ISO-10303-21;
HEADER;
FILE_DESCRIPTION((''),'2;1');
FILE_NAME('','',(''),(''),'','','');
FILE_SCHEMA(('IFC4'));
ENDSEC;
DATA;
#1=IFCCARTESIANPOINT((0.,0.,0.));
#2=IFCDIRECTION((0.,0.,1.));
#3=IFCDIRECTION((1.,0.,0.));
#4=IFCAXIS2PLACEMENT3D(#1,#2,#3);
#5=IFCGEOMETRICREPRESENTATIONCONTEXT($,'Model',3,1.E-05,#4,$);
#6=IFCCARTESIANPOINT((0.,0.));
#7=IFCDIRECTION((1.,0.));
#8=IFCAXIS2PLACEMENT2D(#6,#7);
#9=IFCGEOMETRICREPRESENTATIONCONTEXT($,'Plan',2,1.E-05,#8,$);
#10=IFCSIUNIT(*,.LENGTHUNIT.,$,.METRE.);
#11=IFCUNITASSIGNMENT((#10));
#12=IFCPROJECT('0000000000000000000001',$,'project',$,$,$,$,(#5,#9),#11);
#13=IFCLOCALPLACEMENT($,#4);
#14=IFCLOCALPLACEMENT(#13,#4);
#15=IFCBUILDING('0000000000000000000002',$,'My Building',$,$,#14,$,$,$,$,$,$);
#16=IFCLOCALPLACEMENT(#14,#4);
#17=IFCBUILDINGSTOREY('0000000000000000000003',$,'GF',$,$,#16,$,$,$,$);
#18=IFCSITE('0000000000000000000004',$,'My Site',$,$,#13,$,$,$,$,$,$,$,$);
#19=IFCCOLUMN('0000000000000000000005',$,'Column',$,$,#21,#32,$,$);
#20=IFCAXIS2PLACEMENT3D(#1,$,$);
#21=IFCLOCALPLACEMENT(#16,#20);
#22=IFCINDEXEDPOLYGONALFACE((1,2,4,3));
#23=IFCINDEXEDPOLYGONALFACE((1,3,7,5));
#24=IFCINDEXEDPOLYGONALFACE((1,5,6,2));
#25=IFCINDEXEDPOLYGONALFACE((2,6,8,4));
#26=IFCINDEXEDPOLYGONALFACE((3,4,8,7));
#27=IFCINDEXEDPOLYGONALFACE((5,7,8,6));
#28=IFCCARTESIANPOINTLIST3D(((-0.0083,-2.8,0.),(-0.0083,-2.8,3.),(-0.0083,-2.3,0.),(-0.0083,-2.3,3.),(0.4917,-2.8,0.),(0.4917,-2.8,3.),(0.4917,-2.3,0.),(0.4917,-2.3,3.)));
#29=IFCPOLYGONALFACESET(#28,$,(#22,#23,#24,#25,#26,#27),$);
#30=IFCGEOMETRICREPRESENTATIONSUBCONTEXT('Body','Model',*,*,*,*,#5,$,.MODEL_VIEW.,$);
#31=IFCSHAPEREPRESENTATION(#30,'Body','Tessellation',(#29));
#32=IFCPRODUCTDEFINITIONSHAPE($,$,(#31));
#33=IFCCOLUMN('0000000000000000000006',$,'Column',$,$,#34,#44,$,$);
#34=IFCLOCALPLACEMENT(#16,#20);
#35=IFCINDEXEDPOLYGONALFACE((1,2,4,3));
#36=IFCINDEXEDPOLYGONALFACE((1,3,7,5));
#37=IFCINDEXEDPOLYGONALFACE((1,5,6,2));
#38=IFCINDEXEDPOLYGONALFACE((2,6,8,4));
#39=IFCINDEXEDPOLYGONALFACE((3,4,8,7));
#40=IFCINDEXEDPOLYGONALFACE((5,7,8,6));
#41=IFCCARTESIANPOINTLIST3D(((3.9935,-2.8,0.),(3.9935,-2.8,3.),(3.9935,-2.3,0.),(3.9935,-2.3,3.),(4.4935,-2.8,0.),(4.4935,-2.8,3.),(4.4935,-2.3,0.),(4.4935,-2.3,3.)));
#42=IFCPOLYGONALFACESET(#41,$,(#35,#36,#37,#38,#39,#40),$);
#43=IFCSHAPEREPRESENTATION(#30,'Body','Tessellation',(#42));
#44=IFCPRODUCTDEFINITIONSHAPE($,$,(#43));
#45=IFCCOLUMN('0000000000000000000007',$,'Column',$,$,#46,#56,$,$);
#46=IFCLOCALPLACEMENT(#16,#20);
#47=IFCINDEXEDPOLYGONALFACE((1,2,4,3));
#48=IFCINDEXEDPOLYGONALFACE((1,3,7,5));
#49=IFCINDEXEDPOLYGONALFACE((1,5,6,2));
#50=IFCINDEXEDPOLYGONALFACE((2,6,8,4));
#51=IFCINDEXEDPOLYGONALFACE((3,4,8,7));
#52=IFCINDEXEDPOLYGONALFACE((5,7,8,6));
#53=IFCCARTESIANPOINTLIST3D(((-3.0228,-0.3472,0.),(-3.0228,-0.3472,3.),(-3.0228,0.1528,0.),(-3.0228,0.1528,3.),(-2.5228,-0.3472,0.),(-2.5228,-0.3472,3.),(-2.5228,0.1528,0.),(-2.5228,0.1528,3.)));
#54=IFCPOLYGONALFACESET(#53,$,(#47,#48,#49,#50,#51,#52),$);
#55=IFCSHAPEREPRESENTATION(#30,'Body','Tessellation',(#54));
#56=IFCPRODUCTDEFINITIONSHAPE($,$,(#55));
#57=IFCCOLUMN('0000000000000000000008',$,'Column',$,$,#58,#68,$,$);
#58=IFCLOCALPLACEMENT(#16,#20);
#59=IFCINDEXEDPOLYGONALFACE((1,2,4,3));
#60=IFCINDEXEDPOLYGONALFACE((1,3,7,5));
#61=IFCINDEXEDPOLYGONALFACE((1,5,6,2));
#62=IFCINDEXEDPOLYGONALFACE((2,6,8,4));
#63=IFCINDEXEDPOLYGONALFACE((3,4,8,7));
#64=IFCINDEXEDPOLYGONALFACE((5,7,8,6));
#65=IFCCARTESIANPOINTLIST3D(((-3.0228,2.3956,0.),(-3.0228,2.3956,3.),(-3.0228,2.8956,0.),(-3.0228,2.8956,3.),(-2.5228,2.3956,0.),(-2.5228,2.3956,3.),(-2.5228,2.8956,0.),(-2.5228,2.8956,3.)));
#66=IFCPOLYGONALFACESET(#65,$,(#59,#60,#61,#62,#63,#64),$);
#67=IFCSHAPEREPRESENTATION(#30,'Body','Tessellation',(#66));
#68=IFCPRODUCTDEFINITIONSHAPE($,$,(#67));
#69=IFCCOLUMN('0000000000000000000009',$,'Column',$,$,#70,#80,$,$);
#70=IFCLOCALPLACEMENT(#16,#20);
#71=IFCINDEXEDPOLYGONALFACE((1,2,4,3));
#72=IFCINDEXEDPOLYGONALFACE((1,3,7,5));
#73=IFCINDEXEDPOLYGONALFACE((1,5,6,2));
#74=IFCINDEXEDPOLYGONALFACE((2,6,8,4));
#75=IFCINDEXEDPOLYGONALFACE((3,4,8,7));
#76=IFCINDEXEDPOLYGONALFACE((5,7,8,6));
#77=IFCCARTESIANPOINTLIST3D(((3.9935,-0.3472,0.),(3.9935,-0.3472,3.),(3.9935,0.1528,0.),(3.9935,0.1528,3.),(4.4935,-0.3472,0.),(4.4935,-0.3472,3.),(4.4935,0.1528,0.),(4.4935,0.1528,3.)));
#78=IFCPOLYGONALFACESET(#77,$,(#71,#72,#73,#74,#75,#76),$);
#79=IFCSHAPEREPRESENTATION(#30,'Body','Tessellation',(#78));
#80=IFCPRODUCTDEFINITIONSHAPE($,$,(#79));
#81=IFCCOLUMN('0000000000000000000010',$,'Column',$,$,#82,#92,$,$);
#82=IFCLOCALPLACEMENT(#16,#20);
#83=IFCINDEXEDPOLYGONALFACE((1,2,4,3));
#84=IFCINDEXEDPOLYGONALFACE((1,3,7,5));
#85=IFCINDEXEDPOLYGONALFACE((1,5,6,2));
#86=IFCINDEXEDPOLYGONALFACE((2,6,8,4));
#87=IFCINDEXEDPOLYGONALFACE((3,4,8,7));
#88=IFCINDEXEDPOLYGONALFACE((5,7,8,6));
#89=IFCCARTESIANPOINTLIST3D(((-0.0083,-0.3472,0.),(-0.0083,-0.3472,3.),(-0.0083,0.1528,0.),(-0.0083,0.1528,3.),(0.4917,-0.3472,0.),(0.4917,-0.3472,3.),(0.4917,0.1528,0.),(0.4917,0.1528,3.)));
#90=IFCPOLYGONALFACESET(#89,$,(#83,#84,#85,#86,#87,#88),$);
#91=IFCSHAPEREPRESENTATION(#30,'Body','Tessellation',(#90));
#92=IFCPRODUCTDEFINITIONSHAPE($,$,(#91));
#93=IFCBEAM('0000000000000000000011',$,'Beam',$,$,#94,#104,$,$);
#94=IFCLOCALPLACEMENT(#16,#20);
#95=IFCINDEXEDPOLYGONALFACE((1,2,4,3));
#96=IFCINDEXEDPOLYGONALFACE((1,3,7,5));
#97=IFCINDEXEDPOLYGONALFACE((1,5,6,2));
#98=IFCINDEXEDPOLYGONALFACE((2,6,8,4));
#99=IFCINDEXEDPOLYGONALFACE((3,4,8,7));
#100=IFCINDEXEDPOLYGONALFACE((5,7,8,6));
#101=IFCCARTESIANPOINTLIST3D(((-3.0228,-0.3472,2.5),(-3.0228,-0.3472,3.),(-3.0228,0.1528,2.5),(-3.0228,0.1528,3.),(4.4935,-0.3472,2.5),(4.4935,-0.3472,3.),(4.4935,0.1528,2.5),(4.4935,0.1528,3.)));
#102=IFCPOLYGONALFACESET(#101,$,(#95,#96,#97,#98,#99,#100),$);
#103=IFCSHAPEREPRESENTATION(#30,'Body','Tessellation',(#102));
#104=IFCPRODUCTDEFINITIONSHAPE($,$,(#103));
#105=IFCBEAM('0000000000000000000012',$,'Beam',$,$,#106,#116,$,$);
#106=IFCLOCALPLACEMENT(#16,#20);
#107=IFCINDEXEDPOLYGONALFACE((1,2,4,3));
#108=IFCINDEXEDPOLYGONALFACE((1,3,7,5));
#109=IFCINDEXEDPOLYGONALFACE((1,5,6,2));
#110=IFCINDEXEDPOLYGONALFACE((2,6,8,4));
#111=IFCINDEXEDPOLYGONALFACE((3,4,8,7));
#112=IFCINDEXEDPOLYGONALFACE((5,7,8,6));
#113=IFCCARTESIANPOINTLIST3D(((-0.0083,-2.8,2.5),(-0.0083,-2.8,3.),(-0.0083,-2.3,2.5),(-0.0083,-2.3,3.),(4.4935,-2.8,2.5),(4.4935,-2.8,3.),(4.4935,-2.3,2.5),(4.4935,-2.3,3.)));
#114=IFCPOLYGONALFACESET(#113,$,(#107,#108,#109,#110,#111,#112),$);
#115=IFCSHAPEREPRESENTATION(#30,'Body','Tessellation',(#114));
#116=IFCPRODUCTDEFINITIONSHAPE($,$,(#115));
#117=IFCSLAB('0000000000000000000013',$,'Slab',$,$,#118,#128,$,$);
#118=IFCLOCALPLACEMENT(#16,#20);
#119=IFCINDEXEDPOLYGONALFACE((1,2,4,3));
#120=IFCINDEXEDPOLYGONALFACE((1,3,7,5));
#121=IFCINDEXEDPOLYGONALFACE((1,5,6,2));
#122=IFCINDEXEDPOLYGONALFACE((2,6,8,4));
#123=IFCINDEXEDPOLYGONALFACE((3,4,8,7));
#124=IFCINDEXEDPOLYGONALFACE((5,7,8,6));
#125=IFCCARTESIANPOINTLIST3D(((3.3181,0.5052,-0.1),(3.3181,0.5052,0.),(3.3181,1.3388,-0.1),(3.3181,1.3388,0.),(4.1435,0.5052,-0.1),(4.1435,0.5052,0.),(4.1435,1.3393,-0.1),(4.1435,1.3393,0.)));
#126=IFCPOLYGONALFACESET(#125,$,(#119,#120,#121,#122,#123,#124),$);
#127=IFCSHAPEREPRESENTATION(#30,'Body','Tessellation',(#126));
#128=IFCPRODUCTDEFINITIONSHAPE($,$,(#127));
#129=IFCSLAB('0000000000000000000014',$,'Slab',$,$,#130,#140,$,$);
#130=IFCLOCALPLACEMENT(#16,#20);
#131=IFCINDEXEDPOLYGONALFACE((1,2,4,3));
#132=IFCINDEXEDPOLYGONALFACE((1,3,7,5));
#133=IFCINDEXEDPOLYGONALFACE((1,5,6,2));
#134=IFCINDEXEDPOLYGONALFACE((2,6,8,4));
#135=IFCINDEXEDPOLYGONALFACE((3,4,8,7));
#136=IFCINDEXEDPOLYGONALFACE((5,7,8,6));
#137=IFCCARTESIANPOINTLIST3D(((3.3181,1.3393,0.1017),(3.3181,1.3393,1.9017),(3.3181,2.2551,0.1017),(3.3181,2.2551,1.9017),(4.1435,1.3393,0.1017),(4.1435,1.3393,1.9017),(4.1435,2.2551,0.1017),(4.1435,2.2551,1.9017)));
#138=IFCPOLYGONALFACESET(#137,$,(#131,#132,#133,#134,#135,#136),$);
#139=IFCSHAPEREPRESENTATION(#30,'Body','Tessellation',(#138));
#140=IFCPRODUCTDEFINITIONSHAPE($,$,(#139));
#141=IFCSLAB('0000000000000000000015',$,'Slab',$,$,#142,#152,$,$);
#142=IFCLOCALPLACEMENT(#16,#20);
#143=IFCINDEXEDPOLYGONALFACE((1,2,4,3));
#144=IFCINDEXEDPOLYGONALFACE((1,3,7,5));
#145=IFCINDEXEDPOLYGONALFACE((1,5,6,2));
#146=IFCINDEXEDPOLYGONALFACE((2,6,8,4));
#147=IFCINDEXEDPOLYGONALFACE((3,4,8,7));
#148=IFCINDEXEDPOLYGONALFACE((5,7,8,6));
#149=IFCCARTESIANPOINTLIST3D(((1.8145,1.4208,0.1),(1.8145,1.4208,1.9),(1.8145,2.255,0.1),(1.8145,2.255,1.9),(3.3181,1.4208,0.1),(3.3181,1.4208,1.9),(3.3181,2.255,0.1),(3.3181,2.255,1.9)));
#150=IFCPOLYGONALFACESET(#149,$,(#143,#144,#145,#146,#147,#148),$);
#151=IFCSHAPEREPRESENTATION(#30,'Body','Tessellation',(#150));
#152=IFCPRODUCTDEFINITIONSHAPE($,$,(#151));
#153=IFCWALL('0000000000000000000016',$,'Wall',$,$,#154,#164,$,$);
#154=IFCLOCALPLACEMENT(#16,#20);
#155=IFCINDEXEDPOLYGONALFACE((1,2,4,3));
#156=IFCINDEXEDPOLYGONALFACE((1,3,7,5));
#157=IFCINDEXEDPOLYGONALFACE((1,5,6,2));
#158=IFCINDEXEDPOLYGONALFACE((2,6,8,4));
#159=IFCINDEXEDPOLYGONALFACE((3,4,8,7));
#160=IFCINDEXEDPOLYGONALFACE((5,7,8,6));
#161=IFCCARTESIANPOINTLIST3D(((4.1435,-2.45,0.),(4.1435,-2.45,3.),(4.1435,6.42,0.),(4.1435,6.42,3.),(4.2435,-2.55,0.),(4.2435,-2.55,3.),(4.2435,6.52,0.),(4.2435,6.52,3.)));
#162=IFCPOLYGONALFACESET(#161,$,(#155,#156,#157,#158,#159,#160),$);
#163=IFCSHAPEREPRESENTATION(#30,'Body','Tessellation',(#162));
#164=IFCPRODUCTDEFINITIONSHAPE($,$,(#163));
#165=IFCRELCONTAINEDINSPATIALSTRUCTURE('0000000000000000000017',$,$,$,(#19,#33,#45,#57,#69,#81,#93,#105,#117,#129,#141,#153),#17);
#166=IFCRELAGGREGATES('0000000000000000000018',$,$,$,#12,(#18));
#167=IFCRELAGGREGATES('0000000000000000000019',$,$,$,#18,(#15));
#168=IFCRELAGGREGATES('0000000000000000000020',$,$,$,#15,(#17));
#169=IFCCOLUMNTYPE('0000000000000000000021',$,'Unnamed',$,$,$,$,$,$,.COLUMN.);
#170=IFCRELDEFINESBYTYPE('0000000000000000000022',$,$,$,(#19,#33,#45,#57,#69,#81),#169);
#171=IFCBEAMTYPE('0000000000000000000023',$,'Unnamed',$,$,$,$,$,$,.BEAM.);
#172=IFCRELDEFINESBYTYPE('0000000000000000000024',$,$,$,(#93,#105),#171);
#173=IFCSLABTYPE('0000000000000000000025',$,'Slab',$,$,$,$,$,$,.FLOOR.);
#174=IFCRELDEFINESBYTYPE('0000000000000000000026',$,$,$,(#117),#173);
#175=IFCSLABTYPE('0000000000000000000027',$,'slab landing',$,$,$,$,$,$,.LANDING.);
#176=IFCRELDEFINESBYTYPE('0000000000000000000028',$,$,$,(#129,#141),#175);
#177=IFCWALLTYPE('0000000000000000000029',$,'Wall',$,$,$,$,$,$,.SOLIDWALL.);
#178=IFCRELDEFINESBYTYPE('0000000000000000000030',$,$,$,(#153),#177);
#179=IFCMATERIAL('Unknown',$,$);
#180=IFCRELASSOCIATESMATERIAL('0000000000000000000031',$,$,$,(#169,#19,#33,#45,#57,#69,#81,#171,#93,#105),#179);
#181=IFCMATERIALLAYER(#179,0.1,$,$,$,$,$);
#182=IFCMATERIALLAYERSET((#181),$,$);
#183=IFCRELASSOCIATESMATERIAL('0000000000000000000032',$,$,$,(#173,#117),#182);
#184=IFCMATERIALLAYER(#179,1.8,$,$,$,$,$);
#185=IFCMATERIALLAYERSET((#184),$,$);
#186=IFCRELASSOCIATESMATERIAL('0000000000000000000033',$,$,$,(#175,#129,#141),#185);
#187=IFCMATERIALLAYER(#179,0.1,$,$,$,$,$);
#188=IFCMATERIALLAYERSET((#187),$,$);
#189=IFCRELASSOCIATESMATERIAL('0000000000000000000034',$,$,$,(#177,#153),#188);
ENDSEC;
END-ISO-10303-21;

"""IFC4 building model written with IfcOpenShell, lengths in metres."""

from ifc_helpers import new_model, si_unit, frame, origin_with_axes, origin_2d_with_axis, place, context, subcontext, project, spatial, line, indexed_curve, rectangle, outline, extrude, material, layer, layer_set, layer_usage, material_profile, profile_set, profile_usage, type_object, element, save


model = new_model("IFC4")

# Units and contexts
model_context = context("Model", 3, precision=1e-05, world=origin_with_axes())
plan_context = context("Plan", 2, precision=1e-05, world=origin_2d_with_axis())
body_context_1 = subcontext(model_context, "Body", "Model", "MODEL_VIEW")
ifc_project = project(units=[si_unit("LENGTHUNIT", "METRE")], contexts=[model_context, plan_context])

# Site, building, storey
site_placement = place(None, origin_with_axes())
site = spatial("IfcSite", under=ifc_project, at=site_placement, Name="My Site")
building_placement = place(site_placement, origin_with_axes())
building = spatial("IfcBuilding", under=site, at=building_placement, Name="My Building")
storey_placement = place(building_placement, origin_with_axes())
storey = spatial("IfcBuildingStorey", under=building, at=storey_placement, Name="GF")

# Columns
ifc_material = material(Name="Unknown")
ifc_material_profile_1 = material_profile(ifc_material, rectangle(XDim=0.5, YDim=0.5))
ifc_profile_set_1 = profile_set([ifc_material_profile_1])
ifc_profile_usage_1 = profile_usage(ifc_profile_set_1, cardinal=5)
column_type = type_object("IfcColumnType", Name="Unnamed", PredefinedType="COLUMN", material=ifc_profile_set_1)
column_1_placement = place(storey_placement, frame((0.2417, -2.55, 0.0), z_axis=(0.0, 0.0, 1.0), x_axis=(1.0, 0.0, 0.0)))
element("IfcColumn", 1, at=column_1_placement, inside=storey, type_object=column_type, material=ifc_profile_usage_1, Name="Column", context=body_context_1, shape_type="SweptSolid", body=[
    extrude(rectangle(XDim=0.5, YDim=0.5), origin_with_axes(), (0.0, 0.0, 1.0), 3.0),
])
ifc_profile_usage_2 = profile_usage(ifc_profile_set_1, cardinal=5)
column_2_placement = place(storey_placement, frame((4.2435, -2.55, 0.0), z_axis=(0.0, 0.0, 1.0), x_axis=(1.0, 0.0, 0.0)))
element("IfcColumn", 2, at=column_2_placement, inside=storey, type_object=column_type, material=ifc_profile_usage_2, Name="Column", context=body_context_1, shape_type="SweptSolid", body=[
    extrude(rectangle(XDim=0.5, YDim=0.5), origin_with_axes(), (0.0, 0.0, 1.0), 3.0),
])
ifc_profile_usage_3 = profile_usage(ifc_profile_set_1, cardinal=5)
column_3_placement = place(storey_placement, frame((-2.7728, -0.0972, 0.0), z_axis=(0.0, 0.0, 1.0), x_axis=(1.0, 0.0, 0.0)))
element("IfcColumn", 3, at=column_3_placement, inside=storey, type_object=column_type, material=ifc_profile_usage_3, Name="Column", context=body_context_1, shape_type="SweptSolid", body=[
    extrude(rectangle(XDim=0.5, YDim=0.5), origin_with_axes(), (0.0, 0.0, 1.0), 3.0),
])
ifc_profile_usage_4 = profile_usage(ifc_profile_set_1, cardinal=5)
column_4_placement = place(storey_placement, frame((-2.7728, 2.6456, 0.0), z_axis=(0.0, 0.0, 1.0), x_axis=(1.0, 0.0, 0.0)))
element("IfcColumn", 4, at=column_4_placement, inside=storey, type_object=column_type, material=ifc_profile_usage_4, Name="Column", context=body_context_1, shape_type="SweptSolid", body=[
    extrude(rectangle(XDim=0.5, YDim=0.5), origin_with_axes(), (0.0, 0.0, 1.0), 3.0),
])
ifc_profile_usage_5 = profile_usage(ifc_profile_set_1, cardinal=5)
column_5_placement = place(storey_placement, frame((4.2435, -0.0972, 0.0), z_axis=(0.0, 0.0, 1.0), x_axis=(1.0, 0.0, 0.0)))
element("IfcColumn", 5, at=column_5_placement, inside=storey, type_object=column_type, material=ifc_profile_usage_5, Name="Column", context=body_context_1, shape_type="SweptSolid", body=[
    extrude(rectangle(XDim=0.5, YDim=0.5), origin_with_axes(), (0.0, 0.0, 1.0), 3.0),
])
ifc_profile_usage_6 = profile_usage(ifc_profile_set_1, cardinal=5)
column_6_placement = place(storey_placement, frame((0.2417, -0.0972, 0.0), z_axis=(0.0, 0.0, 1.0), x_axis=(1.0, 0.0, 0.0)))
element("IfcColumn", 6, at=column_6_placement, inside=storey, type_object=column_type, material=ifc_profile_usage_6, Name="Column", context=body_context_1, shape_type="SweptSolid", body=[
    extrude(rectangle(XDim=0.5, YDim=0.5), origin_with_axes(), (0.0, 0.0, 1.0), 3.0),
])

# Beams
ifc_material_profile_2 = material_profile(ifc_material, rectangle(XDim=0.5, YDim=0.5))
ifc_profile_set_2 = profile_set([ifc_material_profile_2])
ifc_profile_usage_7 = profile_usage(ifc_profile_set_2, cardinal=7)
beam_type = type_object("IfcBeamType", Name="Unnamed", PredefinedType="BEAM", material=ifc_profile_set_2)
beam_1_placement = place(storey_placement, frame((-3.0228, 0.1528, 3.0), z_axis=(1.0, 0.0, 0.0), x_axis=(0.0, 1.0, 0.0)))
element("IfcBeam", 7, at=beam_1_placement, inside=storey, type_object=beam_type, material=ifc_profile_usage_7, Name="Beam", context=body_context_1, shape_type="SweptSolid", body=[
    extrude(rectangle(XDim=0.5, YDim=0.5), frame((-0.25, -0.25, 0.0), z_axis=(0.0, 0.0, 1.0), x_axis=(1.0, 0.0, 0.0)), (0.0, 0.0, 1.0), 7.5163),
])
ifc_profile_usage_8 = profile_usage(ifc_profile_set_2, cardinal=7)
beam_2_placement = place(storey_placement, frame((4.4935, -2.8, 3.0), z_axis=(-1.0, 0.0, 0.0), x_axis=(0.0, -1.0, 0.0)))
element("IfcBeam", 8, at=beam_2_placement, inside=storey, type_object=beam_type, material=ifc_profile_usage_8, Name="Beam", context=body_context_1, shape_type="SweptSolid", body=[
    extrude(rectangle(XDim=0.5, YDim=0.5), frame((-0.25, -0.25, 0.0), z_axis=(0.0, 0.0, 1.0), x_axis=(1.0, 0.0, 0.0)), (0.0, 0.0, 1.0), 4.5018),
])

# Slabs
ifc_layer_1 = layer(ifc_material, 0.1)
ifc_layer_set_1 = layer_set([ifc_layer_1])
ifc_layer_usage_1 = layer_usage(ifc_layer_set_1, "AXIS3", "POSITIVE", -0.1)
slab_type_1 = type_object("IfcSlabType", Name="Slab", PredefinedType="FLOOR", material=ifc_layer_set_1)
slab_1_placement = place(storey_placement, frame((3.3181, 1.3388, 0.0), z_axis=(0.0, 0.0, 1.0), x_axis=(1.0, 0.0, 0.0)))
element("IfcSlab", 9, at=slab_1_placement, inside=storey, type_object=slab_type_1, material=ifc_layer_usage_1, Name="Slab", context=body_context_1, shape_type="SweptSolid", body=[
    extrude(outline(indexed_curve([(0.0, 0.0), (0.0, -0.8336), (0.8254, -0.8336), (0.8254, 0.0005), (0.0, 0.0)])), frame((0.0, 0.0, -0.1), z_axis=(0.0, 0.0, 1.0), x_axis=(1.0, 0.0, 0.0)), (0.0, 0.0, 1.0), 0.1),
])
ifc_layer_2 = layer(ifc_material, 1.8)
ifc_layer_set_2 = layer_set([ifc_layer_2])
slab_type_2 = type_object("IfcSlabType", Name="slab landing", PredefinedType="LANDING", material=ifc_layer_set_2)
ifc_layer_usage_2 = layer_usage(ifc_layer_set_2, "AXIS3", "POSITIVE", -1.8)
slab_2_placement = place(storey_placement, frame((4.1435, 1.3393, 1.9017), z_axis=(0.0, 0.0, 1.0), x_axis=(1.0, 0.0, 0.0)))
element("IfcSlab", 10, at=slab_2_placement, inside=storey, type_object=slab_type_2, material=ifc_layer_usage_2, Name="Slab", context=body_context_1, shape_type="SweptSolid", body=[
    extrude(outline(indexed_curve([(0.0, 0.0), (0.0, 0.9157), (-0.8254, 0.9157), (-0.8254, 0.0), (0.0, 0.0)])), frame((0.0, 0.0, -1.8), z_axis=(0.0, 0.0, 1.0), x_axis=(1.0, 0.0, 0.0)), (0.0, 0.0, 1.0), 1.8),
])
ifc_layer_usage_3 = layer_usage(ifc_layer_set_2, "AXIS3", "POSITIVE", -1.8)
slab_3_placement = place(storey_placement, frame((3.3181, 1.4208, 1.9), z_axis=(0.0, 0.0, 1.0), x_axis=(1.0, 0.0, 0.0)))
element("IfcSlab", 11, at=slab_3_placement, inside=storey, type_object=slab_type_2, material=ifc_layer_usage_3, Name="Slab", context=body_context_1, shape_type="SweptSolid", body=[
    extrude(outline(indexed_curve([(0.0, 0.0), (-1.5036, 0.0), (-1.5036, 0.8342), (0.0, 0.8342), (0.0, 0.0)])), frame((0.0, 0.0, -1.8), z_axis=(0.0, 0.0, 1.0), x_axis=(1.0, 0.0, 0.0)), (0.0, 0.0, 1.0), 1.8),
])

# Shared definitions
ifc_layer_3 = layer(ifc_material, 0.1)
ifc_layer_set_3 = layer_set([ifc_layer_3])
wall_type = type_object("IfcWallType", Name="Wall", PredefinedType="SOLIDWALL", material=ifc_layer_set_3)

# Wall
ifc_layer_usage_4 = layer_usage(ifc_layer_set_3, "AXIS2", "POSITIVE", 0.0)
wall_1_placement = place(storey_placement, frame((4.2435, -2.45, 0.0), z_axis=(0.0, 0.0, 1.0), x_axis=(0.0, 1.0, 0.0)))
element("IfcWall", 12, at=wall_1_placement, inside=storey, type_object=wall_type, material=ifc_layer_usage_4, Name="Wall", context=body_context_1, shape_type="SweptSolid", body=[
    extrude(outline(indexed_curve([(-0.1, 0.0), (0.0, 0.1), (8.87, 0.1), (8.97, 0.0)], segments=[line(1, 2, 3, 4, 1)])), origin_with_axes(), (0.0, 0.0, 1.0), 3.0),
])

save(model, "model.ifc")
